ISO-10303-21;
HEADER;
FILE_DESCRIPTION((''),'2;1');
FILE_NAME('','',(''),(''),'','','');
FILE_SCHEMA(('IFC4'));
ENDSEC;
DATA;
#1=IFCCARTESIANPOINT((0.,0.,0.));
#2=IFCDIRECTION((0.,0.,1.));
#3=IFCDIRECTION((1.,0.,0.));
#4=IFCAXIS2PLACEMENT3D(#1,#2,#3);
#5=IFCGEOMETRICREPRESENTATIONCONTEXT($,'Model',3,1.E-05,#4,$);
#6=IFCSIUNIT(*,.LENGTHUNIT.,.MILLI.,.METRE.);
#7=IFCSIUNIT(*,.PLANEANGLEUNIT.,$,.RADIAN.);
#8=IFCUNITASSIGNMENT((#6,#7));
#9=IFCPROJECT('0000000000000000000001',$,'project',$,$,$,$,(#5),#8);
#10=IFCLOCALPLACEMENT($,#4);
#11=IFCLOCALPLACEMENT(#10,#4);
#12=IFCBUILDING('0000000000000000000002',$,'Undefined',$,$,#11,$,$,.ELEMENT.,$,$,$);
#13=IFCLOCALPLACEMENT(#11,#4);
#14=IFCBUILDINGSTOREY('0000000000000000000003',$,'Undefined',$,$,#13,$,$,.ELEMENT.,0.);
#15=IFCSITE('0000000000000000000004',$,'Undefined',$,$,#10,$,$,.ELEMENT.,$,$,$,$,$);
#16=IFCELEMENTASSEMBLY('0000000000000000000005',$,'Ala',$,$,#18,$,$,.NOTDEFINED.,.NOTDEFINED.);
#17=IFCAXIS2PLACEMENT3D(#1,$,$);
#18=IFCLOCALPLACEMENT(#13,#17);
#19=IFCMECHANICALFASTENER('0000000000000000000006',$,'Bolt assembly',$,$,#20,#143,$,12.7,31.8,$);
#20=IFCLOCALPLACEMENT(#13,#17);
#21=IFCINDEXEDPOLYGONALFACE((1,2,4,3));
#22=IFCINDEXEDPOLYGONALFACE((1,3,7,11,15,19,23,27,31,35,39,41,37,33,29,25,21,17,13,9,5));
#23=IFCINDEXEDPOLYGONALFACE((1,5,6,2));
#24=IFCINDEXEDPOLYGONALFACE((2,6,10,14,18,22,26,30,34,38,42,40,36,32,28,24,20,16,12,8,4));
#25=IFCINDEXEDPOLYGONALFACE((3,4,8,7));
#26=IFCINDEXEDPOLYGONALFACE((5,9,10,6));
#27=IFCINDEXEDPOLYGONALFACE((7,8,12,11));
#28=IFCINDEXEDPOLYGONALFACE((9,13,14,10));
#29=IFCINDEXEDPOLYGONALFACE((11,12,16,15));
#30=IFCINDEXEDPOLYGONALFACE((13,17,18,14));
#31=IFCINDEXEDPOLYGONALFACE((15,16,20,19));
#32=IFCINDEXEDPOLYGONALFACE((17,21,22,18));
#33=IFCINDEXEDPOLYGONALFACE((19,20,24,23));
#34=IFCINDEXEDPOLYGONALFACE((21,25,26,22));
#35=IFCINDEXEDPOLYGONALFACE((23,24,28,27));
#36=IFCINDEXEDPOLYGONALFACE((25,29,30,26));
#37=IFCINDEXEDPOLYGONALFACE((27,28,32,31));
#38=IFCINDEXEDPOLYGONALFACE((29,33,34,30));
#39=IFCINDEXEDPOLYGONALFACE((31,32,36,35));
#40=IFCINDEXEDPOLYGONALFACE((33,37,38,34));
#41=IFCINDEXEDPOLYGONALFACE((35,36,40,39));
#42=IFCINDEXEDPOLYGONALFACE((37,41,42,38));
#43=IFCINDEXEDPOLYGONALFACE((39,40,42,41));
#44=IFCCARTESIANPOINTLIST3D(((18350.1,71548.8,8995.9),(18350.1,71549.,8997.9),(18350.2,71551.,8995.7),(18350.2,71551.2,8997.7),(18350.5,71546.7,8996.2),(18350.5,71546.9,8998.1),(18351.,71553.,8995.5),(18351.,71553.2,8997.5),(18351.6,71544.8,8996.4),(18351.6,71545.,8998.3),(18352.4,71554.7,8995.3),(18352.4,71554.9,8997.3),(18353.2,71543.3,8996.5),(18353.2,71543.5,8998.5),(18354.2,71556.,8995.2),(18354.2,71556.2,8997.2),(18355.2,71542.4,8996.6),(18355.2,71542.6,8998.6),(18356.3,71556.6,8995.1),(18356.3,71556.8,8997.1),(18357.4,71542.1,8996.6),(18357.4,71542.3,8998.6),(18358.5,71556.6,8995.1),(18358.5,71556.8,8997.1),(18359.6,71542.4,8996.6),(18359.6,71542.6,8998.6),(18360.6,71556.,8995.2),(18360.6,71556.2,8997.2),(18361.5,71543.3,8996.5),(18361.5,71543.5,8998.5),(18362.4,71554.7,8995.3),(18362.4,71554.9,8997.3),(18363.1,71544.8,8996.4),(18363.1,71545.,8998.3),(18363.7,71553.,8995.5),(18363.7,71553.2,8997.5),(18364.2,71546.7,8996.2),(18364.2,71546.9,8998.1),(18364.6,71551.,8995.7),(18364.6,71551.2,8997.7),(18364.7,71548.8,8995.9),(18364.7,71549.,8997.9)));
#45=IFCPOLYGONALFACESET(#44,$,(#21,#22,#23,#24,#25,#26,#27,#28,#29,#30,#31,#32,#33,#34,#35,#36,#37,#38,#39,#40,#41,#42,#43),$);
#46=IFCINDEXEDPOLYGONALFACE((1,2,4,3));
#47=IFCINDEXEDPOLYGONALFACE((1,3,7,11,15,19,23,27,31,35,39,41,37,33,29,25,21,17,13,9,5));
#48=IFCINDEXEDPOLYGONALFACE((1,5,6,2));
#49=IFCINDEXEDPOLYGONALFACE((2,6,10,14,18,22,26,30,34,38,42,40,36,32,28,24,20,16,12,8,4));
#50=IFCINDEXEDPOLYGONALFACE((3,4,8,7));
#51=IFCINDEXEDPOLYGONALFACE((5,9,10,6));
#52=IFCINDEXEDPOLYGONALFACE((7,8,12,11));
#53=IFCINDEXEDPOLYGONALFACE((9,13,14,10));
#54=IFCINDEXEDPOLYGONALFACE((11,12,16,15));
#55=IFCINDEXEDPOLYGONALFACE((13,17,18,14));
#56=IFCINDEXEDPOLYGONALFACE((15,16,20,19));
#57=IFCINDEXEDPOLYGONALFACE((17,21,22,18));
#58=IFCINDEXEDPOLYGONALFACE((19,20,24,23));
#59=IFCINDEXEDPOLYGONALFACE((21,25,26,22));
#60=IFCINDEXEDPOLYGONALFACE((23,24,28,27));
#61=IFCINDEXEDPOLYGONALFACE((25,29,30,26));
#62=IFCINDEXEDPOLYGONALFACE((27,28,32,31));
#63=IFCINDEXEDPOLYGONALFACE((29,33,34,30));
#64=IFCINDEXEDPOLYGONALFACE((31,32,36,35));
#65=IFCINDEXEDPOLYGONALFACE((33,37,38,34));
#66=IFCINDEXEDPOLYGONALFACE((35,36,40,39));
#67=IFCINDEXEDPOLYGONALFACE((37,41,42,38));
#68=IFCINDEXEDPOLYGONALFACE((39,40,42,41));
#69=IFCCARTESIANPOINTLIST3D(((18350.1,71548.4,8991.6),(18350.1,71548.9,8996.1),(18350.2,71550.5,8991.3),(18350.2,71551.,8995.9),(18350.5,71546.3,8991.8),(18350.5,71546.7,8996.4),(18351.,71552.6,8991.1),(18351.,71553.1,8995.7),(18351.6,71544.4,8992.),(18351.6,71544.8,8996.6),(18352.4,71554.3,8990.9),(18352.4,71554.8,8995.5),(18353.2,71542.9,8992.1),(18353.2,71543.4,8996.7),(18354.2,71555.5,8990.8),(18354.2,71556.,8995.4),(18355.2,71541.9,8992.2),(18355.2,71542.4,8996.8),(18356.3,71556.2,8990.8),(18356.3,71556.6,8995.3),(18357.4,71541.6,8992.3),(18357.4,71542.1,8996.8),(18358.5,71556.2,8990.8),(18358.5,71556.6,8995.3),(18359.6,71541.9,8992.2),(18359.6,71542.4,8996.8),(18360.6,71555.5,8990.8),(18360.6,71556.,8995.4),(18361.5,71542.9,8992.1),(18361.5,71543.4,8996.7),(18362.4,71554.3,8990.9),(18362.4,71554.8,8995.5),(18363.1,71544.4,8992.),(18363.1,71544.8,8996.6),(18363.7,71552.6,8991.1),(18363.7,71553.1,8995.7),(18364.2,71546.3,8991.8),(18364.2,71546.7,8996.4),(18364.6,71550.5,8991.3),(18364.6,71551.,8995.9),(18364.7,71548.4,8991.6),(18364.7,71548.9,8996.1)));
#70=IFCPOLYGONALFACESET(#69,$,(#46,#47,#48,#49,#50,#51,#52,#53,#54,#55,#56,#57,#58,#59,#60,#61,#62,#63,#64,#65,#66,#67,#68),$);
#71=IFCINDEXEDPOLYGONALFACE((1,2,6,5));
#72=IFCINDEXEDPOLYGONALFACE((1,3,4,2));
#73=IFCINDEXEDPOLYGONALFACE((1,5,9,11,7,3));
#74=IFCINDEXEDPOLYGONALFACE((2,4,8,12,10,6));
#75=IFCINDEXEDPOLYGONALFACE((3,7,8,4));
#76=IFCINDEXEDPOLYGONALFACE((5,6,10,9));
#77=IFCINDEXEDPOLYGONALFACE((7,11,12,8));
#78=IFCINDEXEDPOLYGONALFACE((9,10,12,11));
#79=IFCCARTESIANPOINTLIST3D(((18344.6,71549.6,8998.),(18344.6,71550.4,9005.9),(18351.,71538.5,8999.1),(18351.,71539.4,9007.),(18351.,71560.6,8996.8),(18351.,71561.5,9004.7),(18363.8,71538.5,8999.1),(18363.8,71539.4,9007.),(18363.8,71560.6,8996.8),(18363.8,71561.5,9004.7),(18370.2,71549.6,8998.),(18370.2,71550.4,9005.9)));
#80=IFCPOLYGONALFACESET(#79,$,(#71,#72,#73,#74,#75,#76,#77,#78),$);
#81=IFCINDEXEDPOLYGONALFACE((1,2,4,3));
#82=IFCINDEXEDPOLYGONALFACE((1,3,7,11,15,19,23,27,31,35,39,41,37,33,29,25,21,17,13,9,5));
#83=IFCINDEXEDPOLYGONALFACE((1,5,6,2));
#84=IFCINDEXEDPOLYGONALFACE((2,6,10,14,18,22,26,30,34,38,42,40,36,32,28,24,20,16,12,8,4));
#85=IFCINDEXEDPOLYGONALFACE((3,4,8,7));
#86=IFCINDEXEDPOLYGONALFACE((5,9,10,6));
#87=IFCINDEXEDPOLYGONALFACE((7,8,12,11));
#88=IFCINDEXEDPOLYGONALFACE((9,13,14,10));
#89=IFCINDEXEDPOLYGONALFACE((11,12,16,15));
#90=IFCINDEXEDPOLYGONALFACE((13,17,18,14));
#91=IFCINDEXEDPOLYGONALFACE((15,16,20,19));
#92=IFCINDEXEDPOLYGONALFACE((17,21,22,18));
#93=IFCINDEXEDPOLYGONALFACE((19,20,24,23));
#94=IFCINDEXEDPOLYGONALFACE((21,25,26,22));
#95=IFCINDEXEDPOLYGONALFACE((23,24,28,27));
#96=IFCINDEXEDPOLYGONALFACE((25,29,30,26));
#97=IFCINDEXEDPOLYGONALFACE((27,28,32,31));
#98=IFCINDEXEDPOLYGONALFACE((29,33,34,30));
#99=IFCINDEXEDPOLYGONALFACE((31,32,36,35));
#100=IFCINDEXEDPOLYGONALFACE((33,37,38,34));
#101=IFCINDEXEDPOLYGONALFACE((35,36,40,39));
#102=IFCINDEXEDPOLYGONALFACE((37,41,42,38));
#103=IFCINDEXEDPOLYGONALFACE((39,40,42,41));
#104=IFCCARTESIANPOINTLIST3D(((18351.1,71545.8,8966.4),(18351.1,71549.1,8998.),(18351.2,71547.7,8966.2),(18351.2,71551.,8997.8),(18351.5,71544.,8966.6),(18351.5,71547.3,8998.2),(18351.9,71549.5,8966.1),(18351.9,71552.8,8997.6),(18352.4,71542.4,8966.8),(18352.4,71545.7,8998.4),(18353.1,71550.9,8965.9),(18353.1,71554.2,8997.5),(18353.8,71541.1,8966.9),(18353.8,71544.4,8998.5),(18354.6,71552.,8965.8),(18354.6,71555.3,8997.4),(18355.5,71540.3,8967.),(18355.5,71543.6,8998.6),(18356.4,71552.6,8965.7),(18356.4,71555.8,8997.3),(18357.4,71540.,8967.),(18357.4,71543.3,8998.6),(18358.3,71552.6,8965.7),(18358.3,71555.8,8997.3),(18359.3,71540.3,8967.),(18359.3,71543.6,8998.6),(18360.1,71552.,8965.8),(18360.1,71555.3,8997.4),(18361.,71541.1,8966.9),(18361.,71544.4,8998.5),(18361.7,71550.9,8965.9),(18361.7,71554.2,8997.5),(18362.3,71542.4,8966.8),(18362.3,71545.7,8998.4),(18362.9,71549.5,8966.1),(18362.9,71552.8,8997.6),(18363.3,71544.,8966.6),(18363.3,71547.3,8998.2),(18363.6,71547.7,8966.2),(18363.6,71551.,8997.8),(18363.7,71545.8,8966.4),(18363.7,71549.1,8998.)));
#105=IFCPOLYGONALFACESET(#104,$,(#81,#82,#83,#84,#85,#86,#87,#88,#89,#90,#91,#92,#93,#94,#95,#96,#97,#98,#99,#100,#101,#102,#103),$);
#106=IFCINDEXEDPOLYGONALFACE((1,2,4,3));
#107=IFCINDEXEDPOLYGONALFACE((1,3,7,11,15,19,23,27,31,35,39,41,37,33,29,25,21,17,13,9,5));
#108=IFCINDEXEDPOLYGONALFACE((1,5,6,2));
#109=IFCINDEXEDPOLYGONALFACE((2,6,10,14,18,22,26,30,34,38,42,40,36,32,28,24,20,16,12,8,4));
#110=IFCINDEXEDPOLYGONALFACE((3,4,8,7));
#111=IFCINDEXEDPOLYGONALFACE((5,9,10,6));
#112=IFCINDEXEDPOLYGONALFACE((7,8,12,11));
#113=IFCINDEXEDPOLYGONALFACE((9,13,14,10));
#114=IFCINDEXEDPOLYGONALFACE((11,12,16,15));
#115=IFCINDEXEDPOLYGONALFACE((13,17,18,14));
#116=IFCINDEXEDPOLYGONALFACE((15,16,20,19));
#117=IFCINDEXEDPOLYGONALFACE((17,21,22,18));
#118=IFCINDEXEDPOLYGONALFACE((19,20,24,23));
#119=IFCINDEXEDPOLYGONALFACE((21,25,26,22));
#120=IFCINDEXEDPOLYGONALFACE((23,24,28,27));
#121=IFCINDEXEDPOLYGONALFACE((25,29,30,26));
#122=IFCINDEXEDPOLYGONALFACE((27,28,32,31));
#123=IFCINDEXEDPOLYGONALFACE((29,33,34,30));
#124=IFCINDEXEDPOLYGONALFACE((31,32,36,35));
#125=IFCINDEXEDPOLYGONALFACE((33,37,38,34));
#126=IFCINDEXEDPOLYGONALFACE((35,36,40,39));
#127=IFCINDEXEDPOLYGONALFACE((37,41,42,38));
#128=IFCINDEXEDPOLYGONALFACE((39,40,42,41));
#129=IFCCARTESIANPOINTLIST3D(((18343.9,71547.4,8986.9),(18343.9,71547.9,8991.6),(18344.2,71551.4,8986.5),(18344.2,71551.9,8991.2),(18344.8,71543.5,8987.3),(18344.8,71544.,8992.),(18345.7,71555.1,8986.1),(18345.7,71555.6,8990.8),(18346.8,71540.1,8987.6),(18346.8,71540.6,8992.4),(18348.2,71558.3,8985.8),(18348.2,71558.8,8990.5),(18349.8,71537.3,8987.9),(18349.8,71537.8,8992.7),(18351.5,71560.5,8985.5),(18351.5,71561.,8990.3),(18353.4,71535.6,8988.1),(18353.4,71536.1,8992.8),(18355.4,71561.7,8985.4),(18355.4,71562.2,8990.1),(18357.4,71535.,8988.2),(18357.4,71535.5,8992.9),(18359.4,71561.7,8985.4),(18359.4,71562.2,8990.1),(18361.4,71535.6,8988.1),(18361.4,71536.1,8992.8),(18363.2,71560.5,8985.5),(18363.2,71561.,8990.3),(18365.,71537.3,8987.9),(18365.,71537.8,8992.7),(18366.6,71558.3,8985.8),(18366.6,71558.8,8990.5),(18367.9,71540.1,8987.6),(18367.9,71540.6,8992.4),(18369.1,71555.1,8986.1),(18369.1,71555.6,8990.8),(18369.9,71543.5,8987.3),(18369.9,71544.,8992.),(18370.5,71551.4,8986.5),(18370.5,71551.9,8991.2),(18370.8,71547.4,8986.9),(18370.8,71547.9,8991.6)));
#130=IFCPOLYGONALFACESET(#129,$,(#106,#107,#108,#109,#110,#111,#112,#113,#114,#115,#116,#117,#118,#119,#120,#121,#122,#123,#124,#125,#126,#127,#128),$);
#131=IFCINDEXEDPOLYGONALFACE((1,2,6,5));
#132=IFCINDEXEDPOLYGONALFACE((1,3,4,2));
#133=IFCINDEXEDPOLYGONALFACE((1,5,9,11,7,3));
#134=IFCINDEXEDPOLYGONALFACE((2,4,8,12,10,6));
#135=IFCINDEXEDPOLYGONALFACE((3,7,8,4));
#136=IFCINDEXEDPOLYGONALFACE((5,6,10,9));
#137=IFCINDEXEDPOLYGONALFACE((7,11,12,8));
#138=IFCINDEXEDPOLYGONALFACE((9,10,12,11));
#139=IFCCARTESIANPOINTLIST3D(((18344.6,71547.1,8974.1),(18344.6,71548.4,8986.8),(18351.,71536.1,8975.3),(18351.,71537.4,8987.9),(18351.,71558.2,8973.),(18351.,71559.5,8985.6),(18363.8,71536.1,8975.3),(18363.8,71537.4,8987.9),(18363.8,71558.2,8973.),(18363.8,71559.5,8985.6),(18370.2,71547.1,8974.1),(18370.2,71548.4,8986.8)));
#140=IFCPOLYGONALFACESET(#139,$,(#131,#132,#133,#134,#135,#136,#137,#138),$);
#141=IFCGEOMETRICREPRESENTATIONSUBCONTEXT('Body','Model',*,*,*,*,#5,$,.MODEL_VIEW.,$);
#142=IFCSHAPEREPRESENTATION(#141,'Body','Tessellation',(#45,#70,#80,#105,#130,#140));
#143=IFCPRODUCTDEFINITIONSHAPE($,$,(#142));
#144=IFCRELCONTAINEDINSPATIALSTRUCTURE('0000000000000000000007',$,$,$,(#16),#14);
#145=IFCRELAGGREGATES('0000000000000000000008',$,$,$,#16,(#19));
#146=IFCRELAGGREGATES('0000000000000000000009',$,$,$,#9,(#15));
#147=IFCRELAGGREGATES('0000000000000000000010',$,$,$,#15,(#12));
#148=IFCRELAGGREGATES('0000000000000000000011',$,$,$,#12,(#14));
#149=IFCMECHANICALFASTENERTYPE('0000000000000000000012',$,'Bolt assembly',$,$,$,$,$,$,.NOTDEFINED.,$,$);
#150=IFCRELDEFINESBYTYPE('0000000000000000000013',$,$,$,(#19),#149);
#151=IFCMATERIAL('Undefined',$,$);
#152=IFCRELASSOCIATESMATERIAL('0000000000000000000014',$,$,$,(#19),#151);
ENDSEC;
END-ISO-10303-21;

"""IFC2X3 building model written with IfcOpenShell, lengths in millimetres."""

from ifc_helpers import new_model, si_unit, frame, origin_with_axes, origin_2d_with_axis, place, context, subcontext, project, spatial, polyline, circle, outline, extrude, source, transform, mapped, material, type_object, element, aggregate, save


model = new_model("IFC2X3")

# Units and contexts
model_context = context("Model", 3, precision=1e-05, world=origin_with_axes())
body_context = subcontext(model_context, "Body", "Model", "MODEL_VIEW")
ifc_project = project(units=[si_unit("LENGTHUNIT", "METRE", prefix="MILLI"), si_unit("PLANEANGLEUNIT", "RADIAN")], contexts=[model_context])

# Site, building, storey
site_placement = place(None, origin_with_axes())
site = spatial("IfcSite", under=ifc_project, at=site_placement, Name="Undefined", CompositionType="ELEMENT")
building_placement = place(site_placement, origin_with_axes())
building = spatial("IfcBuilding", under=site, at=building_placement, Name="Undefined", CompositionType="ELEMENT")
storey_placement = place(building_placement, origin_with_axes())
storey = spatial("IfcBuildingStorey", under=building, at=storey_placement, Name="Undefined", CompositionType="ELEMENT", Elevation=0.0)

# Element assembly
assembly_1_placement = place(storey_placement, origin_with_axes())
assembly_1 = element("IfcElementAssembly", 1, at=assembly_1_placement, inside=storey, Name="Ala", AssemblyPlace="NOTDEFINED", PredefinedType="NOTDEFINED")

# Shared definitions
ifc_material_1 = material(Name="Undefined")
mechanical_fastener_type = type_object("IfcMechanicalFastenerType", Name="Bolt assembly")

# Mechanical fastener
shared_shape_1 = source(origin_with_axes(), body_context, "Body", "SweptSolid", [
    extrude(circle(Radius=7.3, at=origin_2d_with_axis()), frame((0.0, -1.9, 0.0), z_axis=(0.0, 1.0, 0.0), x_axis=(1.0, 0.0, 0.0)), (0.0, 0.0, 1.0), 2.0),
    extrude(circle(Radius=7.3, at=origin_2d_with_axis()), frame((0.0, -0.1, 0.0), z_axis=(0.0, 1.0, 0.0), x_axis=(1.0, 0.0, 0.0)), (0.0, 0.0, 1.0), 4.6),
    extrude(outline(polyline([(11.1, -6.4), (11.1, 6.4), (0.0, 12.8), (-11.1, 6.4), (-11.1, -6.4), (0.0, -12.8), (11.1, -6.4)])), frame((0.0, -9.9, 0.0), z_axis=(0.0, 1.0, 0.0), x_axis=(1.0, 0.0, 0.0)), (0.0, 0.0, 1.0), 7.9),
    extrude(circle(Radius=6.3, at=origin_2d_with_axis()), frame((0.0, -2.0, 0.0), z_axis=(0.0, 1.0, 0.0), x_axis=(1.0, 0.0, 0.0)), (0.0, 0.0, 1.0), 31.8),
    extrude(circle(Radius=13.5, at=origin_2d_with_axis()), frame((0.0, 4.5, 0.0), z_axis=(0.0, 1.0, 0.0), x_axis=(1.0, 0.0, 0.0)), (0.0, 0.0, 1.0), 4.8),
    extrude(outline(polyline([(11.1, -6.4), (11.1, 6.4), (0.0, 12.8), (-11.1, 6.4), (-11.1, -6.4), (0.0, -12.8), (11.1, -6.4)])), frame((0.0, 9.3, 0.0), z_axis=(0.0, 1.0, 0.0), x_axis=(1.0, 0.0, 0.0)), (0.0, 0.0, 1.0), 12.7),
])
mechanical_fastener_1_placement = place(assembly_1_placement, frame((18357.4, 71549.4, 8996.0), z_axis=(1.0, 0.0, 0.0), x_axis=(0.0, -0.994665, 0.103162)))
mechanical_fastener_1 = element("IfcMechanicalFastener", 2, at=mechanical_fastener_1_placement, type_object=mechanical_fastener_type, material=ifc_material_1, Name="Bolt assembly", NominalDiameter=12.7, NominalLength=31.8, context=body_context, shape_type="MappedRepresentation", body=[
    mapped(shared_shape_1, transform((0.0, 0.0, 0.0))),
])

aggregate(assembly_1, [mechanical_fastener_1])

save(model, "model.ifc")
